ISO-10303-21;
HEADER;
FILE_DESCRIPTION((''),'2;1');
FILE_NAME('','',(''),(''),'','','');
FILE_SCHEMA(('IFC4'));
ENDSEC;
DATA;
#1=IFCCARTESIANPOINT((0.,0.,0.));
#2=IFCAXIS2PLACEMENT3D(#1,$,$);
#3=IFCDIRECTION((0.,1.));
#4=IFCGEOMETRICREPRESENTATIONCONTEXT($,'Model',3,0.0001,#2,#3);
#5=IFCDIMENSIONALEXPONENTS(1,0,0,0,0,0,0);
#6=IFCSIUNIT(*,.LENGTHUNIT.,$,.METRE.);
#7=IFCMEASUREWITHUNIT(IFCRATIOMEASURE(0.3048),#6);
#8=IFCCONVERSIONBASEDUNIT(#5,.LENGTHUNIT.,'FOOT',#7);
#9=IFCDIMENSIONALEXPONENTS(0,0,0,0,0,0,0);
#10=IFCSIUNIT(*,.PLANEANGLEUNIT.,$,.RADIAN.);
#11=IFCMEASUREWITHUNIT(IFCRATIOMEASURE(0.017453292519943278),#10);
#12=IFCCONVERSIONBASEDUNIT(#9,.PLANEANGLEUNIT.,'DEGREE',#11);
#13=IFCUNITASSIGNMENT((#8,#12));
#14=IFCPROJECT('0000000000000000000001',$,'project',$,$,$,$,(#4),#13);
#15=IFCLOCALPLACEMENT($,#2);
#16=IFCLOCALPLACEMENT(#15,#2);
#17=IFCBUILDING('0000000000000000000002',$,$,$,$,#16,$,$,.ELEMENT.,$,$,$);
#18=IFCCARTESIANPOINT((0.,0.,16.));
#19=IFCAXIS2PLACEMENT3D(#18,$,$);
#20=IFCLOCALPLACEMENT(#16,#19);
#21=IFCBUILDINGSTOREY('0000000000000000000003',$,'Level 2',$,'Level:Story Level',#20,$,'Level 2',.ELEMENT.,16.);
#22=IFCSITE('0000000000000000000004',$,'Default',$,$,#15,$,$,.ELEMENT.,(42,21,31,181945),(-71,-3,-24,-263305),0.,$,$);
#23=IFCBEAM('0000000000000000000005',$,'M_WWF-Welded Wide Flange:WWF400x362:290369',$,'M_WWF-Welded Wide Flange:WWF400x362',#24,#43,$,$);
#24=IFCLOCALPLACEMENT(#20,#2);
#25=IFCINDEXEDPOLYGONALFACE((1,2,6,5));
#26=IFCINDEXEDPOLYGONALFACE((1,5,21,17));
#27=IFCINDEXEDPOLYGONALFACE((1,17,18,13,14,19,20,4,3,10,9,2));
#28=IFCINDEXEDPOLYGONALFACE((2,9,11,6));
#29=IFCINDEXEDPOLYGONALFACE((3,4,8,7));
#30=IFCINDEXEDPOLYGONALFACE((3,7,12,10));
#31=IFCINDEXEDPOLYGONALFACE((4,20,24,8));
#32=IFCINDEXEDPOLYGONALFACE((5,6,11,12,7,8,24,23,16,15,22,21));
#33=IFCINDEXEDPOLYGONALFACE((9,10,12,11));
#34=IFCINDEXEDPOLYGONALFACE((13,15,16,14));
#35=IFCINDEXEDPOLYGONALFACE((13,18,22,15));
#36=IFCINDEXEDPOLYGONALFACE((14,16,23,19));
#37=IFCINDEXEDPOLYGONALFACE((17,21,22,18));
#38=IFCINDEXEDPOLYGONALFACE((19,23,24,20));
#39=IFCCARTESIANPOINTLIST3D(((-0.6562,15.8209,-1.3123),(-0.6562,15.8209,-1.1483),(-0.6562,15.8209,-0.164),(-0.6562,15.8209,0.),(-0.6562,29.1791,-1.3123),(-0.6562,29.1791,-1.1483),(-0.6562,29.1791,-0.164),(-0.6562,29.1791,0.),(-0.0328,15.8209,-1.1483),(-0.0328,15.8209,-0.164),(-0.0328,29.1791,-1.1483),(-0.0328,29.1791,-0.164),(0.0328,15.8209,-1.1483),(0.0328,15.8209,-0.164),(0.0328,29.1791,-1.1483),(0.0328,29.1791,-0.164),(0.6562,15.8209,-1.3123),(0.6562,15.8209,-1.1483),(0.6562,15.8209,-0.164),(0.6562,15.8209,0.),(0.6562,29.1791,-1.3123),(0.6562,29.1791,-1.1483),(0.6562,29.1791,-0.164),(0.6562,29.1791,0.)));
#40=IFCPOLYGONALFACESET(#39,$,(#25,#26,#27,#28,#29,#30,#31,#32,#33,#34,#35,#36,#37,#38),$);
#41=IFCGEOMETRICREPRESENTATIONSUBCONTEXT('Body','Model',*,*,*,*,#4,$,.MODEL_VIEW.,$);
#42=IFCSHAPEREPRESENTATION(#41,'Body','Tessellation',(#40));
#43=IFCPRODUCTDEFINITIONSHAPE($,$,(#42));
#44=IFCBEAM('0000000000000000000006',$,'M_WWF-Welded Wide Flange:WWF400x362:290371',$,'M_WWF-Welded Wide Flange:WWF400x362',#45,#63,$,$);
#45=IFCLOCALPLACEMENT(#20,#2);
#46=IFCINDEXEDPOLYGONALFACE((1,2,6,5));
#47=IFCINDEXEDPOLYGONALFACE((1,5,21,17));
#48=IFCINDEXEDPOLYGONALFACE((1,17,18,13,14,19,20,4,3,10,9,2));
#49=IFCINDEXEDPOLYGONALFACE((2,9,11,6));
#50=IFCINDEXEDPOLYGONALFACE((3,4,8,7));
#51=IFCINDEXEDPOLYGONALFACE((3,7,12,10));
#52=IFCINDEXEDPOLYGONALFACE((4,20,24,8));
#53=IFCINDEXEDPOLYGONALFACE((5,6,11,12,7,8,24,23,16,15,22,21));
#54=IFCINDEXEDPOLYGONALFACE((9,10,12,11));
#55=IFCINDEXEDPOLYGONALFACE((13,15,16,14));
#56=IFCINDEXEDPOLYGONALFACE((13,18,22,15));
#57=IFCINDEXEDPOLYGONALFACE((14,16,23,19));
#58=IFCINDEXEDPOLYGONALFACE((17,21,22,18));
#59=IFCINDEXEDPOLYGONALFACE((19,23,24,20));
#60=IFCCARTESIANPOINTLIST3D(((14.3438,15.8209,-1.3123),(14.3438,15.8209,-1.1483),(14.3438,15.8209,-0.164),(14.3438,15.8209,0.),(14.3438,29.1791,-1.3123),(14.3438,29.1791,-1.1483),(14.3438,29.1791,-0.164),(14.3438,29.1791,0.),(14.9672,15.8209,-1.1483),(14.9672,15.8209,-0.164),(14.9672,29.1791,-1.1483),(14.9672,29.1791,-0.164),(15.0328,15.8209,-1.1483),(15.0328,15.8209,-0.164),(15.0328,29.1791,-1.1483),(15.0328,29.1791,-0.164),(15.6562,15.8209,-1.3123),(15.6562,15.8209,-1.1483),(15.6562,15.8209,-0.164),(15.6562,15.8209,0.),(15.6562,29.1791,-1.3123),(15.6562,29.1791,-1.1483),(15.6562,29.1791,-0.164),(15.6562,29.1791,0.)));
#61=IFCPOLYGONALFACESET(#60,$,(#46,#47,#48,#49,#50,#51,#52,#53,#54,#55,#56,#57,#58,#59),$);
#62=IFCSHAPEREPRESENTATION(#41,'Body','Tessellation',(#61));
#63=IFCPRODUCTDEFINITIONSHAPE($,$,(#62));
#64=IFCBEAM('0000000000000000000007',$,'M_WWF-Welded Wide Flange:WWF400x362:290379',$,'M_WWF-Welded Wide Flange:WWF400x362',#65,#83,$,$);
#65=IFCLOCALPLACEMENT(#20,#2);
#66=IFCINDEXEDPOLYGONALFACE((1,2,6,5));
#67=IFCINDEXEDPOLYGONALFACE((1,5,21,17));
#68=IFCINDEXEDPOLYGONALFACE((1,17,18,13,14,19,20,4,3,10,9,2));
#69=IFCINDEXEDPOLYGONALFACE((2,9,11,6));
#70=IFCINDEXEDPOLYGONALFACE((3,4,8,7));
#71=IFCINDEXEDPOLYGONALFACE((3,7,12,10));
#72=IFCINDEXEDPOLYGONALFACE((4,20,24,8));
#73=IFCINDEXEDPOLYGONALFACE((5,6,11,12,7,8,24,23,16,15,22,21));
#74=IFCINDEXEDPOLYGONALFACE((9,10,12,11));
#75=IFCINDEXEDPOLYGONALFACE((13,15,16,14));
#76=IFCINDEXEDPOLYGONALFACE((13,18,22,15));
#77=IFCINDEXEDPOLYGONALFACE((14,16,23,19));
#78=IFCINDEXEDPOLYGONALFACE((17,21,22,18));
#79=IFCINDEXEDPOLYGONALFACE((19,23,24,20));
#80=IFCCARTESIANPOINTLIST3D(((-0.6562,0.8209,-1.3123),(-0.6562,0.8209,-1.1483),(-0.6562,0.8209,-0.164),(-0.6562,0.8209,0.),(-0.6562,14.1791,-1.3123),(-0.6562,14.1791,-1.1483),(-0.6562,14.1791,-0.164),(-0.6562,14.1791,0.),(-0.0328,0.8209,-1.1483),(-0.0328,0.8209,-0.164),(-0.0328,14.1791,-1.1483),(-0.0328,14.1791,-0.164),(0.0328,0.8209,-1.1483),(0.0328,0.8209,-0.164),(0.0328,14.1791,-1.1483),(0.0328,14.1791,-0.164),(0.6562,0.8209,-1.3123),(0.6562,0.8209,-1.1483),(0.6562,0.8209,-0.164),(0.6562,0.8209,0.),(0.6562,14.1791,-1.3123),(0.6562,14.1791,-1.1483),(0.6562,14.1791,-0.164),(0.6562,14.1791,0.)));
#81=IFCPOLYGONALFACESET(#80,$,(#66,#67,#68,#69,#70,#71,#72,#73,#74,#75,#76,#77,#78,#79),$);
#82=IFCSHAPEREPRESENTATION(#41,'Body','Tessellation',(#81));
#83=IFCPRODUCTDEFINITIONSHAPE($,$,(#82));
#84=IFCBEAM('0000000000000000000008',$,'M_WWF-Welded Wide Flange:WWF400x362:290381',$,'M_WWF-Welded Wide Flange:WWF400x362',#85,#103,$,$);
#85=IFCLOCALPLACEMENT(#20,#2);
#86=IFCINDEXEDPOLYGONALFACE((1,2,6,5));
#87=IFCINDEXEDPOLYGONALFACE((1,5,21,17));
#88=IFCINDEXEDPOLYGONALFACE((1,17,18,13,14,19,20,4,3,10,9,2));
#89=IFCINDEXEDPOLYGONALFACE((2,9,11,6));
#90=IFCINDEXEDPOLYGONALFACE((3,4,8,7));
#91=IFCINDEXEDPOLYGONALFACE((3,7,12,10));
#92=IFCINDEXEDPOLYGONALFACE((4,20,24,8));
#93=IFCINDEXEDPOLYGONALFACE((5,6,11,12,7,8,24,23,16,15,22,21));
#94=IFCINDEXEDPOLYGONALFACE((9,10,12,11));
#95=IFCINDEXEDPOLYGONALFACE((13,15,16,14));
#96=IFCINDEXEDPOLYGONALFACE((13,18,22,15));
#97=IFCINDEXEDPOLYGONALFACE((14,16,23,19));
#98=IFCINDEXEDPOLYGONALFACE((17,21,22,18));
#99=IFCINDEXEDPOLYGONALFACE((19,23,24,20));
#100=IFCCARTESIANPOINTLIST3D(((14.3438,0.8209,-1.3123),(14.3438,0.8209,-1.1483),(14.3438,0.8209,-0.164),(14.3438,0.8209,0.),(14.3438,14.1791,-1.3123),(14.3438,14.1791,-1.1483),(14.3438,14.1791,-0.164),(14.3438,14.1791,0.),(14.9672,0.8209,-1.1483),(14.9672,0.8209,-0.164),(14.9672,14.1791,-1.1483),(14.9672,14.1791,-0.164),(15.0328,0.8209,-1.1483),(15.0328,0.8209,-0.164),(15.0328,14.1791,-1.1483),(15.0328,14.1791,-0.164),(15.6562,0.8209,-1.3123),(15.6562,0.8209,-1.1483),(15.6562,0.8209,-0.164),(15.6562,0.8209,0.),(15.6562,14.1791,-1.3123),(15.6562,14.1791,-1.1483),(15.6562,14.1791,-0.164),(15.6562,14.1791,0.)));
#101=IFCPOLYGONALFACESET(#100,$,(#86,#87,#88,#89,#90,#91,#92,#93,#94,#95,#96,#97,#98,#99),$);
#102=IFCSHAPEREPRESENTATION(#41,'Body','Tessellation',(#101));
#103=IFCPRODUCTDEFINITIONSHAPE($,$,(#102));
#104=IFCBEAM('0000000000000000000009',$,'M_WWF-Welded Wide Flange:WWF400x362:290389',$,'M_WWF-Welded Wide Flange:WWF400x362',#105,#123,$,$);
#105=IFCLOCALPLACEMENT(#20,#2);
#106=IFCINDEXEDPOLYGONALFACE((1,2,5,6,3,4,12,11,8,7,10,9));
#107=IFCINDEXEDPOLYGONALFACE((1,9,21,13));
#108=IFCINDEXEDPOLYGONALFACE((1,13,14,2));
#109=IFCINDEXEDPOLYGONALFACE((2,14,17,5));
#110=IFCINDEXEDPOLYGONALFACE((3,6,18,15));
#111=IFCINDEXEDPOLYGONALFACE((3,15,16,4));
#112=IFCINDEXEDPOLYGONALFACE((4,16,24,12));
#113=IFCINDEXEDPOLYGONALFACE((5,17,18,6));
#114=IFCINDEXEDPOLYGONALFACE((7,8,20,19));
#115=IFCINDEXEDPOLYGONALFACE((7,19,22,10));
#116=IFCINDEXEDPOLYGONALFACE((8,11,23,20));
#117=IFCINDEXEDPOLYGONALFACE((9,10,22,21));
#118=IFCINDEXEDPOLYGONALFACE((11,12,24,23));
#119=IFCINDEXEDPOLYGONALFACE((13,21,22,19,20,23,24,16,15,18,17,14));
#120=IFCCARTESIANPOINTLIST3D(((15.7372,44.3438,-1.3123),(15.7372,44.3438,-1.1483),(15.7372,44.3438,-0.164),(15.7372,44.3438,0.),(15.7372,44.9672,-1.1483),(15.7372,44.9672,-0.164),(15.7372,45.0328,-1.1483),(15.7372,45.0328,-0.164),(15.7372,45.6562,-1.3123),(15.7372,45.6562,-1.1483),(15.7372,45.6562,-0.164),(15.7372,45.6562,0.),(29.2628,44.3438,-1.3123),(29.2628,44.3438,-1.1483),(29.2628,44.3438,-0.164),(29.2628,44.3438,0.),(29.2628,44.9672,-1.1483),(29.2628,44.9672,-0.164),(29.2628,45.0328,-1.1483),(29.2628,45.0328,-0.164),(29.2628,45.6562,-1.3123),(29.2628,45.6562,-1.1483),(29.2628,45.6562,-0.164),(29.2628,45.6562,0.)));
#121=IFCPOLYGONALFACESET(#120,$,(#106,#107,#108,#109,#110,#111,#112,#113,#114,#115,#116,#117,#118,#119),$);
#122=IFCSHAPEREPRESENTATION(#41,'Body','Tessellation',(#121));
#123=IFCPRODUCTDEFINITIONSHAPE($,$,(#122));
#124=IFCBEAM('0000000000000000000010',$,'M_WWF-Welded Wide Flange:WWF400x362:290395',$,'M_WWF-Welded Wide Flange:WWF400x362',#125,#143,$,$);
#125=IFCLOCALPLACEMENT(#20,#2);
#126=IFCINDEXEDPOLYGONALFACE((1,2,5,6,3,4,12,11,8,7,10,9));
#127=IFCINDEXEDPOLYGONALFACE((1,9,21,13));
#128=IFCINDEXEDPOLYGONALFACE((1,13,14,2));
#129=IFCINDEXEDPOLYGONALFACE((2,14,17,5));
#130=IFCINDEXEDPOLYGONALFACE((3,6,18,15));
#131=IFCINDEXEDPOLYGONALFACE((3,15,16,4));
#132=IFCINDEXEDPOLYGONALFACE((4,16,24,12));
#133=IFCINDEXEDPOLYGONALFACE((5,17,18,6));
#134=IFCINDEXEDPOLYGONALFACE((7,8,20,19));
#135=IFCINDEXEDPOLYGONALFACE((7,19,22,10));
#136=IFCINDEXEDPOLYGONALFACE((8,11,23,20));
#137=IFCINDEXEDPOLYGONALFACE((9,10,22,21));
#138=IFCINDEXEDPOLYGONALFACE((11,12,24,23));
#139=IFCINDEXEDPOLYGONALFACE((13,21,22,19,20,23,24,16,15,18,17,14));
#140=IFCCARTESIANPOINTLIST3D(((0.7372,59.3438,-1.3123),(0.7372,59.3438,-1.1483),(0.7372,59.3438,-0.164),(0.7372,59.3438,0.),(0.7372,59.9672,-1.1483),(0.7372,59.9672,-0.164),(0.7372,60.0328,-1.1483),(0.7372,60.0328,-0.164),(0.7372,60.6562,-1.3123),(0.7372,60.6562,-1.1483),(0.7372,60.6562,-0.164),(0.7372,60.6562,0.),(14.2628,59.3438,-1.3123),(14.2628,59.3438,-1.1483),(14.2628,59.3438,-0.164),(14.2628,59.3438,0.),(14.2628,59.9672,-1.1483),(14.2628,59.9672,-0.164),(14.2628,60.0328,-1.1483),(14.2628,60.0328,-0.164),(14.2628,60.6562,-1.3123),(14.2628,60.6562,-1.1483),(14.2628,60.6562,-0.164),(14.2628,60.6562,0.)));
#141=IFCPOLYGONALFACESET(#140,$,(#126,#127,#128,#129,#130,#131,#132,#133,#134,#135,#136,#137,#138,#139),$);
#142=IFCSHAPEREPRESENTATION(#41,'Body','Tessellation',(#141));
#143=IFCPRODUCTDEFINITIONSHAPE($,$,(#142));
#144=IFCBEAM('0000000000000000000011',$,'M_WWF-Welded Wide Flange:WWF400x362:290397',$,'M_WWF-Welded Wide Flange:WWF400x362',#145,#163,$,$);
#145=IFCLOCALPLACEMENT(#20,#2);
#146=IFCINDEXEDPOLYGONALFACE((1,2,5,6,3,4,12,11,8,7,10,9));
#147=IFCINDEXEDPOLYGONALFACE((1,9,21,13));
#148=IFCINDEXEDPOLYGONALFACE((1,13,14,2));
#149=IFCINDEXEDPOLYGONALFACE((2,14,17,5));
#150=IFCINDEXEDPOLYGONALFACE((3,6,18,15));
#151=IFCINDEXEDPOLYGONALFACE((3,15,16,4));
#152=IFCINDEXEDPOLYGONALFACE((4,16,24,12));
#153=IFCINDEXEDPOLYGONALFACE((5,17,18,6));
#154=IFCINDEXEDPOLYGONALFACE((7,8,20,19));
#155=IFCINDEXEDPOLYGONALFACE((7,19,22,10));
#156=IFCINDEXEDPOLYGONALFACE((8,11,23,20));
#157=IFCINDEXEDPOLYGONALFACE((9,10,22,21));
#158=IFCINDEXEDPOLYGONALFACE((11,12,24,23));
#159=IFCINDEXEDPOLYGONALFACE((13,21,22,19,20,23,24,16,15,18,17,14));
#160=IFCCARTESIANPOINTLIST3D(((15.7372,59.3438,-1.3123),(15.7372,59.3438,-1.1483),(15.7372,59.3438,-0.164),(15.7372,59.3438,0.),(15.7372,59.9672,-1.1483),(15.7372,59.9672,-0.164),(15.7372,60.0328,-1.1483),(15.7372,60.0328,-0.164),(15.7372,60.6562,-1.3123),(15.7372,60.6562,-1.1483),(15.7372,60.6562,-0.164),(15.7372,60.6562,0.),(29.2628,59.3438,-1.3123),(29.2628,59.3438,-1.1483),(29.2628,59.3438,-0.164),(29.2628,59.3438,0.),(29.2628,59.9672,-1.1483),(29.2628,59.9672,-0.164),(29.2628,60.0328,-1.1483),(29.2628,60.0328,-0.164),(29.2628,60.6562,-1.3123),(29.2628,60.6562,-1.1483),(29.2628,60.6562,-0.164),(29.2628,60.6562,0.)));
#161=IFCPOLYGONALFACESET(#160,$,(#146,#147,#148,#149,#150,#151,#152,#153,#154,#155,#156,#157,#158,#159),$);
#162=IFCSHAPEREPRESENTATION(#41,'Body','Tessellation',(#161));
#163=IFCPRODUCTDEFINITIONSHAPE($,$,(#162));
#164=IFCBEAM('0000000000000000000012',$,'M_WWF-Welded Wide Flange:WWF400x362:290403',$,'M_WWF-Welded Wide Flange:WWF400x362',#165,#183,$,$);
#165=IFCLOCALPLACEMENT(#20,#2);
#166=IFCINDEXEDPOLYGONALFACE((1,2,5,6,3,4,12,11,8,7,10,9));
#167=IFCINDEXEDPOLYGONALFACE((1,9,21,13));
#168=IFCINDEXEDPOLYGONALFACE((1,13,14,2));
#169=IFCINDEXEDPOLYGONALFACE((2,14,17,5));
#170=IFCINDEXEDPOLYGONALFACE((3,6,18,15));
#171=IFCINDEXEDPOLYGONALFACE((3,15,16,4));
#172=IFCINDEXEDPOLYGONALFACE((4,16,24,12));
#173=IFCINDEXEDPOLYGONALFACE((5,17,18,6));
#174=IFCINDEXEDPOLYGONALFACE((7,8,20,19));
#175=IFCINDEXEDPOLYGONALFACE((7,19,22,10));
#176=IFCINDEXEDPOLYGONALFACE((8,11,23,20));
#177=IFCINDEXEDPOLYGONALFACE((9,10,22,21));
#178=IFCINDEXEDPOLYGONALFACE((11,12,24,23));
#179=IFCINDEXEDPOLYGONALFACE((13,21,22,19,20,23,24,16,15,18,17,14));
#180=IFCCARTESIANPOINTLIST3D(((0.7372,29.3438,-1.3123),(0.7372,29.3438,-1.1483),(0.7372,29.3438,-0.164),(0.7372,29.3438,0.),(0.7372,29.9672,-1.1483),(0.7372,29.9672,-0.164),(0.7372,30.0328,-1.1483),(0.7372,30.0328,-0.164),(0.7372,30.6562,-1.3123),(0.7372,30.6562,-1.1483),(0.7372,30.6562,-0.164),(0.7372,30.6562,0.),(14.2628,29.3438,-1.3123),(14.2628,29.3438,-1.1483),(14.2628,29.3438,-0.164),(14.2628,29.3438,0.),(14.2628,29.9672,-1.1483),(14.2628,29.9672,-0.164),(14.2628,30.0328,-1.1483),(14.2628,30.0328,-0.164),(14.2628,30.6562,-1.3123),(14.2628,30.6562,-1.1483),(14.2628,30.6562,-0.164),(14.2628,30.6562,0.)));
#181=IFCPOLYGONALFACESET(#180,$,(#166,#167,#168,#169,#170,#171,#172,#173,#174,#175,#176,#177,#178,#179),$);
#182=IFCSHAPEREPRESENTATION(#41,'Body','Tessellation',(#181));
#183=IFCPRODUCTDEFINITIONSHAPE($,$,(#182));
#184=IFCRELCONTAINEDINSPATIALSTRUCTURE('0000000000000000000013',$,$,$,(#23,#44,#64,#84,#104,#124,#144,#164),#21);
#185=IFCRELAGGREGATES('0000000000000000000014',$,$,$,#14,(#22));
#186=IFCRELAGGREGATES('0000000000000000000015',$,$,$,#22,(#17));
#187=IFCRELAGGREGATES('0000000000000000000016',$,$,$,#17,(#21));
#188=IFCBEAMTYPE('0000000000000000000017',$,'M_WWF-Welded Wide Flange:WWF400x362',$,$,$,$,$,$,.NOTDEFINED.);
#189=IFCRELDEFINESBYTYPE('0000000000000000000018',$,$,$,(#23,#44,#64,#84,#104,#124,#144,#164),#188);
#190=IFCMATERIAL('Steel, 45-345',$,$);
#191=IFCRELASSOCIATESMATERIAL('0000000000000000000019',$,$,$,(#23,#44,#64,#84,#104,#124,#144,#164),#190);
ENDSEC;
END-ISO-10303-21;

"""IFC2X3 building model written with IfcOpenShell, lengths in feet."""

from ifc_helpers import new_model, entity, si_unit, converted_unit, direction, frame, frame_2d, origin, place, context, subcontext, project, spatial, i_section, extrude, material, type_object, element, save


model = new_model("IFC2X3")

# Units and contexts
model_context = context("Model", 3, precision=0.0001, world=origin(), true_north=direction((0.0, 1.0)))
body_context = subcontext(model_context, "Body", "Model", "MODEL_VIEW")
ifc_project = project(units=[converted_unit("LENGTHUNIT", "FOOT", entity("IfcRatioMeasure", 0.3048), si_unit("LENGTHUNIT", "METRE"), dimensions=[1, 0, 0, 0, 0, 0, 0]), converted_unit("PLANEANGLEUNIT", "DEGREE", entity("IfcRatioMeasure", 0.017453292519943278), si_unit("PLANEANGLEUNIT", "RADIAN"), dimensions=[0, 0, 0, 0, 0, 0, 0])], contexts=[model_context])

# Site, building, storey
site_placement = place(None, origin())
site = spatial("IfcSite", under=ifc_project, at=site_placement, Name="Default", CompositionType="ELEMENT", RefLatitude=(42, 21, 31, 181945), RefLongitude=(-71, -3, -24, -263305), RefElevation=0.0)
building_placement = place(site_placement, origin())
building = spatial("IfcBuilding", under=site, at=building_placement, CompositionType="ELEMENT")
storey_placement = place(building_placement, frame((0.0, 0.0, 16.0)))
storey = spatial("IfcBuildingStorey", under=building, at=storey_placement, Name="Level 2", ObjectType="Level:Story Level", LongName="Level 2", CompositionType="ELEMENT", Elevation=16.0)

# Shared definitions
ifc_material = material(Name="Steel, 45-345")

# Beams
beam_type = type_object("IfcBeamType", Name="M_WWF-Welded Wide Flange:WWF400x362", PredefinedType="NOTDEFINED")
beam_1_placement = place(storey_placement, frame((0.0, 15.0, 0.0), z_axis=(0.0, 0.0, 1.0), x_axis=(0.0, 1.0, 0.0)))
element("IfcBeam", 1, at=beam_1_placement, inside=storey, type_object=beam_type, material=ifc_material, Name="M_WWF-Welded Wide Flange:WWF400x362:290369", ObjectType="M_WWF-Welded Wide Flange:WWF400x362", context=body_context, shape_type="SweptSolid", body=[
    extrude(i_section(OverallWidth=1.3123, OverallDepth=1.3123, WebThickness=0.0656, FlangeThickness=0.164, at=frame_2d((0.0, 0.0), x_axis=(0.0, 1.0))), frame((0.8209, 0.0, -0.6562), z_axis=(1.0, 0.0, 0.0), x_axis=(0.0, 0.0, -1.0)), (0.0, 0.0, 1.0), 13.3583),
])
beam_2_placement = place(storey_placement, frame((15.0, 15.0, 0.0), z_axis=(0.0, 0.0, 1.0), x_axis=(0.0, 1.0, 0.0)))
element("IfcBeam", 2, at=beam_2_placement, inside=storey, type_object=beam_type, material=ifc_material, Name="M_WWF-Welded Wide Flange:WWF400x362:290371", ObjectType="M_WWF-Welded Wide Flange:WWF400x362", context=body_context, shape_type="SweptSolid", body=[
    extrude(i_section(OverallWidth=1.3123, OverallDepth=1.3123, WebThickness=0.0656, FlangeThickness=0.164, at=frame_2d((0.0, 0.0), x_axis=(0.0, 1.0))), frame((0.8209, 0.0, -0.6562), z_axis=(1.0, 0.0, 0.0), x_axis=(0.0, 0.0, -1.0)), (0.0, 0.0, 1.0), 13.3583),
])
beam_3_placement = place(storey_placement, frame((0.0, 0.0, 0.0), z_axis=(0.0, 0.0, 1.0), x_axis=(0.0, 1.0, 0.0)))
element("IfcBeam", 3, at=beam_3_placement, inside=storey, type_object=beam_type, material=ifc_material, Name="M_WWF-Welded Wide Flange:WWF400x362:290379", ObjectType="M_WWF-Welded Wide Flange:WWF400x362", context=body_context, shape_type="SweptSolid", body=[
    extrude(i_section(OverallWidth=1.3123, OverallDepth=1.3123, WebThickness=0.0656, FlangeThickness=0.164, at=frame_2d((0.0, 0.0), x_axis=(0.0, 1.0))), frame((0.8209, 0.0, -0.6562), z_axis=(1.0, 0.0, 0.0), x_axis=(0.0, 0.0, -1.0)), (0.0, 0.0, 1.0), 13.3583),
])
beam_4_placement = place(storey_placement, frame((15.0, 0.0, 0.0), z_axis=(0.0, 0.0, 1.0), x_axis=(0.0, 1.0, 0.0)))
element("IfcBeam", 4, at=beam_4_placement, inside=storey, type_object=beam_type, material=ifc_material, Name="M_WWF-Welded Wide Flange:WWF400x362:290381", ObjectType="M_WWF-Welded Wide Flange:WWF400x362", context=body_context, shape_type="SweptSolid", body=[
    extrude(i_section(OverallWidth=1.3123, OverallDepth=1.3123, WebThickness=0.0656, FlangeThickness=0.164, at=frame_2d((0.0, 0.0), x_axis=(0.0, 1.0))), frame((0.8209, 0.0, -0.6562), z_axis=(1.0, 0.0, 0.0), x_axis=(0.0, 0.0, -1.0)), (0.0, 0.0, 1.0), 13.3583),
])
beam_5_placement = place(storey_placement, frame((15.0, 45.0, 0.0)))
element("IfcBeam", 5, at=beam_5_placement, inside=storey, type_object=beam_type, material=ifc_material, Name="M_WWF-Welded Wide Flange:WWF400x362:290389", ObjectType="M_WWF-Welded Wide Flange:WWF400x362", context=body_context, shape_type="SweptSolid", body=[
    extrude(i_section(OverallWidth=1.3123, OverallDepth=1.3123, WebThickness=0.0656, FlangeThickness=0.164, at=frame_2d((0.0, 0.0), x_axis=(0.0, 1.0))), frame((0.7372, 0.0, -0.6562), z_axis=(1.0, 0.0, 0.0), x_axis=(0.0, 0.0, -1.0)), (0.0, 0.0, 1.0), 13.5256),
])
beam_6_placement = place(storey_placement, frame((0.0, 60.0, 0.0)))
element("IfcBeam", 6, at=beam_6_placement, inside=storey, type_object=beam_type, material=ifc_material, Name="M_WWF-Welded Wide Flange:WWF400x362:290395", ObjectType="M_WWF-Welded Wide Flange:WWF400x362", context=body_context, shape_type="SweptSolid", body=[
    extrude(i_section(OverallWidth=1.3123, OverallDepth=1.3123, WebThickness=0.0656, FlangeThickness=0.164, at=frame_2d((0.0, 0.0), x_axis=(0.0, 1.0))), frame((0.7372, 0.0, -0.6562), z_axis=(1.0, 0.0, 0.0), x_axis=(0.0, 0.0, -1.0)), (0.0, 0.0, 1.0), 13.5256),
])
beam_7_placement = place(storey_placement, frame((15.0, 60.0, 0.0)))
element("IfcBeam", 7, at=beam_7_placement, inside=storey, type_object=beam_type, material=ifc_material, Name="M_WWF-Welded Wide Flange:WWF400x362:290397", ObjectType="M_WWF-Welded Wide Flange:WWF400x362", context=body_context, shape_type="SweptSolid", body=[
    extrude(i_section(OverallWidth=1.3123, OverallDepth=1.3123, WebThickness=0.0656, FlangeThickness=0.164, at=frame_2d((0.0, 0.0), x_axis=(0.0, 1.0))), frame((0.7372, 0.0, -0.6562), z_axis=(1.0, 0.0, 0.0), x_axis=(0.0, 0.0, -1.0)), (0.0, 0.0, 1.0), 13.5256),
])
beam_8_placement = place(storey_placement, frame((0.0, 30.0, 0.0)))
element("IfcBeam", 8, at=beam_8_placement, inside=storey, type_object=beam_type, material=ifc_material, Name="M_WWF-Welded Wide Flange:WWF400x362:290403", ObjectType="M_WWF-Welded Wide Flange:WWF400x362", context=body_context, shape_type="SweptSolid", body=[
    extrude(i_section(OverallWidth=1.3123, OverallDepth=1.3123, WebThickness=0.0656, FlangeThickness=0.164, at=frame_2d((0.0, 0.0), x_axis=(0.0, 1.0))), frame((0.7372, 0.0, -0.6562), z_axis=(1.0, 0.0, 0.0), x_axis=(0.0, 0.0, -1.0)), (0.0, 0.0, 1.0), 13.5256),
])

save(model, "model.ifc")
